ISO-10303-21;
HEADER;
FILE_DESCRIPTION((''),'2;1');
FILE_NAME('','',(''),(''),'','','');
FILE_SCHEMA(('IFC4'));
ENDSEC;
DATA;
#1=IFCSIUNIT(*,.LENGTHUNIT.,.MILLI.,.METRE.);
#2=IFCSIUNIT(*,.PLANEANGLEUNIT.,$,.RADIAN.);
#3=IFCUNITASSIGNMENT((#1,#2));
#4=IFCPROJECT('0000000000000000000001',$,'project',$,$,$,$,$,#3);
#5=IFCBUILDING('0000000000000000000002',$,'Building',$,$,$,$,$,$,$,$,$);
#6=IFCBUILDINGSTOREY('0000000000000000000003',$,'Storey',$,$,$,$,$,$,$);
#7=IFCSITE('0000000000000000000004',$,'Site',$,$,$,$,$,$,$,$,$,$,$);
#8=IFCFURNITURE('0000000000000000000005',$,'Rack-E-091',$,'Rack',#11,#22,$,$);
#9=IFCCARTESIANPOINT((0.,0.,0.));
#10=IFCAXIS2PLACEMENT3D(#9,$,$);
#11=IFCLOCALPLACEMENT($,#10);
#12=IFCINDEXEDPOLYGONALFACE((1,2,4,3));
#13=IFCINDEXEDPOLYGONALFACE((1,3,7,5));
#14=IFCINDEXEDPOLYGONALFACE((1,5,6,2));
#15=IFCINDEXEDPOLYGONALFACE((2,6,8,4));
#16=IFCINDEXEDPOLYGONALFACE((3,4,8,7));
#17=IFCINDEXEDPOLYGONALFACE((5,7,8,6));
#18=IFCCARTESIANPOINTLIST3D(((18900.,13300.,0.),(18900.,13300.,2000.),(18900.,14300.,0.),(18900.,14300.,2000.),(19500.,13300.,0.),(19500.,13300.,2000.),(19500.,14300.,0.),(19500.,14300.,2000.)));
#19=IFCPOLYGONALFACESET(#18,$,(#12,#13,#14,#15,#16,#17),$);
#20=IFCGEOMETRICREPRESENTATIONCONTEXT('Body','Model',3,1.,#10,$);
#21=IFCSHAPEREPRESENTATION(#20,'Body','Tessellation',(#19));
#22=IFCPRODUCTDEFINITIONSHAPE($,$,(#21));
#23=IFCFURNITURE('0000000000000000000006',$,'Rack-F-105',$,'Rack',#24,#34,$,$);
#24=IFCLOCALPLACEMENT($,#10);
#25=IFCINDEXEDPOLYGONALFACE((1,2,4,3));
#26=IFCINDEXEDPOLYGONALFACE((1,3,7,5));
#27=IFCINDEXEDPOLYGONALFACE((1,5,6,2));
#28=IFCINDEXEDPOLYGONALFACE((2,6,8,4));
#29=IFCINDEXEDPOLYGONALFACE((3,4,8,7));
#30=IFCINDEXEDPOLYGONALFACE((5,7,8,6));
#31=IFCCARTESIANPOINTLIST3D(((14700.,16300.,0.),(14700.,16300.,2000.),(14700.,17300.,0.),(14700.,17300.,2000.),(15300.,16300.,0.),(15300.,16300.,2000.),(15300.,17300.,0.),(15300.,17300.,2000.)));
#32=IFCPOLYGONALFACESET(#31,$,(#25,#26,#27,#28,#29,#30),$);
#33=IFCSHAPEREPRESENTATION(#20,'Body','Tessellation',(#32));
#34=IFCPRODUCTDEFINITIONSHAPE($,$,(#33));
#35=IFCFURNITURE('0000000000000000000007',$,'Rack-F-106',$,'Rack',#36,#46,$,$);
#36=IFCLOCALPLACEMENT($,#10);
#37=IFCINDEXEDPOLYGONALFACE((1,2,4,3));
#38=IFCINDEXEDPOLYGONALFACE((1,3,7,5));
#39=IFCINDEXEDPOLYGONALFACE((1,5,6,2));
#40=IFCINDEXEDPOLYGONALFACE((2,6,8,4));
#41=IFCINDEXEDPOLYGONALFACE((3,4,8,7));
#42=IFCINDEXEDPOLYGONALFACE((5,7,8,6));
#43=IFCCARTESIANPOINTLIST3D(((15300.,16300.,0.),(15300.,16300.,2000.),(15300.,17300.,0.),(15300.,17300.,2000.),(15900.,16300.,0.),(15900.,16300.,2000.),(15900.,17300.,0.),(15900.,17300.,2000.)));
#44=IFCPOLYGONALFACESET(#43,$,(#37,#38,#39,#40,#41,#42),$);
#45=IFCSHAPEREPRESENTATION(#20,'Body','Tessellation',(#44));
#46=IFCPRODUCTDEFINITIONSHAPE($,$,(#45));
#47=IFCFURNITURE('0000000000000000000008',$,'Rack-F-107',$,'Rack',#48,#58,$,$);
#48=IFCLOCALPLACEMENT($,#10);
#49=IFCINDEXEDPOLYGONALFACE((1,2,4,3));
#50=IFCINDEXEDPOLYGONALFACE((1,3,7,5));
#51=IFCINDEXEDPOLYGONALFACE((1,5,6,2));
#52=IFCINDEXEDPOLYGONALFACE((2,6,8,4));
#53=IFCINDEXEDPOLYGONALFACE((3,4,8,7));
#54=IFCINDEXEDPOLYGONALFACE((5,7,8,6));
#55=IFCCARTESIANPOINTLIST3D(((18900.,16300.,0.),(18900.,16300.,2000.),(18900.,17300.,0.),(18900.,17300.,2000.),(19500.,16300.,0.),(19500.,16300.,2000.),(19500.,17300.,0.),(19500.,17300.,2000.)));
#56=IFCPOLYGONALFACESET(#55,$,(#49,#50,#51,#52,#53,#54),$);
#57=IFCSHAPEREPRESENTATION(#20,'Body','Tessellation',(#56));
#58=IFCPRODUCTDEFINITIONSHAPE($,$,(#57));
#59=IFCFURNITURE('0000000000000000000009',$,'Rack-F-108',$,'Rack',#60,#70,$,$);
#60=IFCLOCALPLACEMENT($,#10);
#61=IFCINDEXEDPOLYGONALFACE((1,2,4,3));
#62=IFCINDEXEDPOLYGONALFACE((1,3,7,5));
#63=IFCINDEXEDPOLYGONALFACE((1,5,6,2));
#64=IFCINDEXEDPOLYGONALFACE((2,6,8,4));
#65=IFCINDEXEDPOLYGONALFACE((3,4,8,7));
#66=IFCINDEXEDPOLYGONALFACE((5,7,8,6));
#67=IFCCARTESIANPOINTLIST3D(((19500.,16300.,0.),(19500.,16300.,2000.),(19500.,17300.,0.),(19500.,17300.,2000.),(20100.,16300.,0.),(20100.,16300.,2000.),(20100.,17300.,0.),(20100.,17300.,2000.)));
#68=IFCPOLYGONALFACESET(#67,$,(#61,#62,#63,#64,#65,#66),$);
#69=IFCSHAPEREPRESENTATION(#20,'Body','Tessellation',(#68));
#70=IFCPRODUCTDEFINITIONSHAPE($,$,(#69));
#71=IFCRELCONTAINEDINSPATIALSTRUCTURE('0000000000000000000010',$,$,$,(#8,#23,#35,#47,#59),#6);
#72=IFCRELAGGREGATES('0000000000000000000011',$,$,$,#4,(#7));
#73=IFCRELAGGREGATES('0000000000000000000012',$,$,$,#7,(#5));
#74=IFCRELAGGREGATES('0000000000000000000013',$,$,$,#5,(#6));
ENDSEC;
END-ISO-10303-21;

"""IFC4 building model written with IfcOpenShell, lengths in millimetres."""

from ifc_helpers import new_model, si_unit, frame, origin, place, context, project, spatial, rectangle, extrude, element, save


model = new_model("IFC4")

# Units and contexts
model_context = context("Model", 3, precision=1.0, world=origin(), identifier="Body")
ifc_project = project(units=[si_unit("LENGTHUNIT", "METRE", prefix="MILLI"), si_unit("PLANEANGLEUNIT", "RADIAN")])

# Site, building, storey
site = spatial("IfcSite", under=ifc_project, Name="Site")
building = spatial("IfcBuilding", under=site, Name="Building")
storey = spatial("IfcBuildingStorey", under=building, Name="Storey")

# Furniture
for number, where, z_axis, x_axis, name in (
    (1, (19200.0, 13800.0, 0.0), (0.0, 0.0, 1.0), (1.0, 0.0, 0.0), "Rack-E-091"),
    (2, (15000.0, 16800.0, 0.0), (0.0, 0.0, 1.0), (1.0, 0.0, 0.0), "Rack-F-105"),
    (3, (15600.0, 16800.0, 0.0), (0.0, 0.0, 1.0), (1.0, 0.0, 0.0), "Rack-F-106"),
    (4, (19200.0, 16800.0, 0.0), (0.0, 0.0, 1.0), (1.0, 0.0, 0.0), "Rack-F-107"),
    (5, (19800.0, 16800.0, 0.0), (0.0, 0.0, 1.0), (1.0, 0.0, 0.0), "Rack-F-108"),
):
    element("IfcFurniture", number, at=place(None, frame(where, z_axis=z_axis, x_axis=x_axis)), inside=storey, Name=name, ObjectType="Rack", context=model_context, shape_type="SweptSolid", body=[
        extrude(rectangle(XDim=600.0, YDim=1000.0), origin(), (0.0, 0.0, 1.0), 2000.0),
    ])

save(model, "model.ifc")
